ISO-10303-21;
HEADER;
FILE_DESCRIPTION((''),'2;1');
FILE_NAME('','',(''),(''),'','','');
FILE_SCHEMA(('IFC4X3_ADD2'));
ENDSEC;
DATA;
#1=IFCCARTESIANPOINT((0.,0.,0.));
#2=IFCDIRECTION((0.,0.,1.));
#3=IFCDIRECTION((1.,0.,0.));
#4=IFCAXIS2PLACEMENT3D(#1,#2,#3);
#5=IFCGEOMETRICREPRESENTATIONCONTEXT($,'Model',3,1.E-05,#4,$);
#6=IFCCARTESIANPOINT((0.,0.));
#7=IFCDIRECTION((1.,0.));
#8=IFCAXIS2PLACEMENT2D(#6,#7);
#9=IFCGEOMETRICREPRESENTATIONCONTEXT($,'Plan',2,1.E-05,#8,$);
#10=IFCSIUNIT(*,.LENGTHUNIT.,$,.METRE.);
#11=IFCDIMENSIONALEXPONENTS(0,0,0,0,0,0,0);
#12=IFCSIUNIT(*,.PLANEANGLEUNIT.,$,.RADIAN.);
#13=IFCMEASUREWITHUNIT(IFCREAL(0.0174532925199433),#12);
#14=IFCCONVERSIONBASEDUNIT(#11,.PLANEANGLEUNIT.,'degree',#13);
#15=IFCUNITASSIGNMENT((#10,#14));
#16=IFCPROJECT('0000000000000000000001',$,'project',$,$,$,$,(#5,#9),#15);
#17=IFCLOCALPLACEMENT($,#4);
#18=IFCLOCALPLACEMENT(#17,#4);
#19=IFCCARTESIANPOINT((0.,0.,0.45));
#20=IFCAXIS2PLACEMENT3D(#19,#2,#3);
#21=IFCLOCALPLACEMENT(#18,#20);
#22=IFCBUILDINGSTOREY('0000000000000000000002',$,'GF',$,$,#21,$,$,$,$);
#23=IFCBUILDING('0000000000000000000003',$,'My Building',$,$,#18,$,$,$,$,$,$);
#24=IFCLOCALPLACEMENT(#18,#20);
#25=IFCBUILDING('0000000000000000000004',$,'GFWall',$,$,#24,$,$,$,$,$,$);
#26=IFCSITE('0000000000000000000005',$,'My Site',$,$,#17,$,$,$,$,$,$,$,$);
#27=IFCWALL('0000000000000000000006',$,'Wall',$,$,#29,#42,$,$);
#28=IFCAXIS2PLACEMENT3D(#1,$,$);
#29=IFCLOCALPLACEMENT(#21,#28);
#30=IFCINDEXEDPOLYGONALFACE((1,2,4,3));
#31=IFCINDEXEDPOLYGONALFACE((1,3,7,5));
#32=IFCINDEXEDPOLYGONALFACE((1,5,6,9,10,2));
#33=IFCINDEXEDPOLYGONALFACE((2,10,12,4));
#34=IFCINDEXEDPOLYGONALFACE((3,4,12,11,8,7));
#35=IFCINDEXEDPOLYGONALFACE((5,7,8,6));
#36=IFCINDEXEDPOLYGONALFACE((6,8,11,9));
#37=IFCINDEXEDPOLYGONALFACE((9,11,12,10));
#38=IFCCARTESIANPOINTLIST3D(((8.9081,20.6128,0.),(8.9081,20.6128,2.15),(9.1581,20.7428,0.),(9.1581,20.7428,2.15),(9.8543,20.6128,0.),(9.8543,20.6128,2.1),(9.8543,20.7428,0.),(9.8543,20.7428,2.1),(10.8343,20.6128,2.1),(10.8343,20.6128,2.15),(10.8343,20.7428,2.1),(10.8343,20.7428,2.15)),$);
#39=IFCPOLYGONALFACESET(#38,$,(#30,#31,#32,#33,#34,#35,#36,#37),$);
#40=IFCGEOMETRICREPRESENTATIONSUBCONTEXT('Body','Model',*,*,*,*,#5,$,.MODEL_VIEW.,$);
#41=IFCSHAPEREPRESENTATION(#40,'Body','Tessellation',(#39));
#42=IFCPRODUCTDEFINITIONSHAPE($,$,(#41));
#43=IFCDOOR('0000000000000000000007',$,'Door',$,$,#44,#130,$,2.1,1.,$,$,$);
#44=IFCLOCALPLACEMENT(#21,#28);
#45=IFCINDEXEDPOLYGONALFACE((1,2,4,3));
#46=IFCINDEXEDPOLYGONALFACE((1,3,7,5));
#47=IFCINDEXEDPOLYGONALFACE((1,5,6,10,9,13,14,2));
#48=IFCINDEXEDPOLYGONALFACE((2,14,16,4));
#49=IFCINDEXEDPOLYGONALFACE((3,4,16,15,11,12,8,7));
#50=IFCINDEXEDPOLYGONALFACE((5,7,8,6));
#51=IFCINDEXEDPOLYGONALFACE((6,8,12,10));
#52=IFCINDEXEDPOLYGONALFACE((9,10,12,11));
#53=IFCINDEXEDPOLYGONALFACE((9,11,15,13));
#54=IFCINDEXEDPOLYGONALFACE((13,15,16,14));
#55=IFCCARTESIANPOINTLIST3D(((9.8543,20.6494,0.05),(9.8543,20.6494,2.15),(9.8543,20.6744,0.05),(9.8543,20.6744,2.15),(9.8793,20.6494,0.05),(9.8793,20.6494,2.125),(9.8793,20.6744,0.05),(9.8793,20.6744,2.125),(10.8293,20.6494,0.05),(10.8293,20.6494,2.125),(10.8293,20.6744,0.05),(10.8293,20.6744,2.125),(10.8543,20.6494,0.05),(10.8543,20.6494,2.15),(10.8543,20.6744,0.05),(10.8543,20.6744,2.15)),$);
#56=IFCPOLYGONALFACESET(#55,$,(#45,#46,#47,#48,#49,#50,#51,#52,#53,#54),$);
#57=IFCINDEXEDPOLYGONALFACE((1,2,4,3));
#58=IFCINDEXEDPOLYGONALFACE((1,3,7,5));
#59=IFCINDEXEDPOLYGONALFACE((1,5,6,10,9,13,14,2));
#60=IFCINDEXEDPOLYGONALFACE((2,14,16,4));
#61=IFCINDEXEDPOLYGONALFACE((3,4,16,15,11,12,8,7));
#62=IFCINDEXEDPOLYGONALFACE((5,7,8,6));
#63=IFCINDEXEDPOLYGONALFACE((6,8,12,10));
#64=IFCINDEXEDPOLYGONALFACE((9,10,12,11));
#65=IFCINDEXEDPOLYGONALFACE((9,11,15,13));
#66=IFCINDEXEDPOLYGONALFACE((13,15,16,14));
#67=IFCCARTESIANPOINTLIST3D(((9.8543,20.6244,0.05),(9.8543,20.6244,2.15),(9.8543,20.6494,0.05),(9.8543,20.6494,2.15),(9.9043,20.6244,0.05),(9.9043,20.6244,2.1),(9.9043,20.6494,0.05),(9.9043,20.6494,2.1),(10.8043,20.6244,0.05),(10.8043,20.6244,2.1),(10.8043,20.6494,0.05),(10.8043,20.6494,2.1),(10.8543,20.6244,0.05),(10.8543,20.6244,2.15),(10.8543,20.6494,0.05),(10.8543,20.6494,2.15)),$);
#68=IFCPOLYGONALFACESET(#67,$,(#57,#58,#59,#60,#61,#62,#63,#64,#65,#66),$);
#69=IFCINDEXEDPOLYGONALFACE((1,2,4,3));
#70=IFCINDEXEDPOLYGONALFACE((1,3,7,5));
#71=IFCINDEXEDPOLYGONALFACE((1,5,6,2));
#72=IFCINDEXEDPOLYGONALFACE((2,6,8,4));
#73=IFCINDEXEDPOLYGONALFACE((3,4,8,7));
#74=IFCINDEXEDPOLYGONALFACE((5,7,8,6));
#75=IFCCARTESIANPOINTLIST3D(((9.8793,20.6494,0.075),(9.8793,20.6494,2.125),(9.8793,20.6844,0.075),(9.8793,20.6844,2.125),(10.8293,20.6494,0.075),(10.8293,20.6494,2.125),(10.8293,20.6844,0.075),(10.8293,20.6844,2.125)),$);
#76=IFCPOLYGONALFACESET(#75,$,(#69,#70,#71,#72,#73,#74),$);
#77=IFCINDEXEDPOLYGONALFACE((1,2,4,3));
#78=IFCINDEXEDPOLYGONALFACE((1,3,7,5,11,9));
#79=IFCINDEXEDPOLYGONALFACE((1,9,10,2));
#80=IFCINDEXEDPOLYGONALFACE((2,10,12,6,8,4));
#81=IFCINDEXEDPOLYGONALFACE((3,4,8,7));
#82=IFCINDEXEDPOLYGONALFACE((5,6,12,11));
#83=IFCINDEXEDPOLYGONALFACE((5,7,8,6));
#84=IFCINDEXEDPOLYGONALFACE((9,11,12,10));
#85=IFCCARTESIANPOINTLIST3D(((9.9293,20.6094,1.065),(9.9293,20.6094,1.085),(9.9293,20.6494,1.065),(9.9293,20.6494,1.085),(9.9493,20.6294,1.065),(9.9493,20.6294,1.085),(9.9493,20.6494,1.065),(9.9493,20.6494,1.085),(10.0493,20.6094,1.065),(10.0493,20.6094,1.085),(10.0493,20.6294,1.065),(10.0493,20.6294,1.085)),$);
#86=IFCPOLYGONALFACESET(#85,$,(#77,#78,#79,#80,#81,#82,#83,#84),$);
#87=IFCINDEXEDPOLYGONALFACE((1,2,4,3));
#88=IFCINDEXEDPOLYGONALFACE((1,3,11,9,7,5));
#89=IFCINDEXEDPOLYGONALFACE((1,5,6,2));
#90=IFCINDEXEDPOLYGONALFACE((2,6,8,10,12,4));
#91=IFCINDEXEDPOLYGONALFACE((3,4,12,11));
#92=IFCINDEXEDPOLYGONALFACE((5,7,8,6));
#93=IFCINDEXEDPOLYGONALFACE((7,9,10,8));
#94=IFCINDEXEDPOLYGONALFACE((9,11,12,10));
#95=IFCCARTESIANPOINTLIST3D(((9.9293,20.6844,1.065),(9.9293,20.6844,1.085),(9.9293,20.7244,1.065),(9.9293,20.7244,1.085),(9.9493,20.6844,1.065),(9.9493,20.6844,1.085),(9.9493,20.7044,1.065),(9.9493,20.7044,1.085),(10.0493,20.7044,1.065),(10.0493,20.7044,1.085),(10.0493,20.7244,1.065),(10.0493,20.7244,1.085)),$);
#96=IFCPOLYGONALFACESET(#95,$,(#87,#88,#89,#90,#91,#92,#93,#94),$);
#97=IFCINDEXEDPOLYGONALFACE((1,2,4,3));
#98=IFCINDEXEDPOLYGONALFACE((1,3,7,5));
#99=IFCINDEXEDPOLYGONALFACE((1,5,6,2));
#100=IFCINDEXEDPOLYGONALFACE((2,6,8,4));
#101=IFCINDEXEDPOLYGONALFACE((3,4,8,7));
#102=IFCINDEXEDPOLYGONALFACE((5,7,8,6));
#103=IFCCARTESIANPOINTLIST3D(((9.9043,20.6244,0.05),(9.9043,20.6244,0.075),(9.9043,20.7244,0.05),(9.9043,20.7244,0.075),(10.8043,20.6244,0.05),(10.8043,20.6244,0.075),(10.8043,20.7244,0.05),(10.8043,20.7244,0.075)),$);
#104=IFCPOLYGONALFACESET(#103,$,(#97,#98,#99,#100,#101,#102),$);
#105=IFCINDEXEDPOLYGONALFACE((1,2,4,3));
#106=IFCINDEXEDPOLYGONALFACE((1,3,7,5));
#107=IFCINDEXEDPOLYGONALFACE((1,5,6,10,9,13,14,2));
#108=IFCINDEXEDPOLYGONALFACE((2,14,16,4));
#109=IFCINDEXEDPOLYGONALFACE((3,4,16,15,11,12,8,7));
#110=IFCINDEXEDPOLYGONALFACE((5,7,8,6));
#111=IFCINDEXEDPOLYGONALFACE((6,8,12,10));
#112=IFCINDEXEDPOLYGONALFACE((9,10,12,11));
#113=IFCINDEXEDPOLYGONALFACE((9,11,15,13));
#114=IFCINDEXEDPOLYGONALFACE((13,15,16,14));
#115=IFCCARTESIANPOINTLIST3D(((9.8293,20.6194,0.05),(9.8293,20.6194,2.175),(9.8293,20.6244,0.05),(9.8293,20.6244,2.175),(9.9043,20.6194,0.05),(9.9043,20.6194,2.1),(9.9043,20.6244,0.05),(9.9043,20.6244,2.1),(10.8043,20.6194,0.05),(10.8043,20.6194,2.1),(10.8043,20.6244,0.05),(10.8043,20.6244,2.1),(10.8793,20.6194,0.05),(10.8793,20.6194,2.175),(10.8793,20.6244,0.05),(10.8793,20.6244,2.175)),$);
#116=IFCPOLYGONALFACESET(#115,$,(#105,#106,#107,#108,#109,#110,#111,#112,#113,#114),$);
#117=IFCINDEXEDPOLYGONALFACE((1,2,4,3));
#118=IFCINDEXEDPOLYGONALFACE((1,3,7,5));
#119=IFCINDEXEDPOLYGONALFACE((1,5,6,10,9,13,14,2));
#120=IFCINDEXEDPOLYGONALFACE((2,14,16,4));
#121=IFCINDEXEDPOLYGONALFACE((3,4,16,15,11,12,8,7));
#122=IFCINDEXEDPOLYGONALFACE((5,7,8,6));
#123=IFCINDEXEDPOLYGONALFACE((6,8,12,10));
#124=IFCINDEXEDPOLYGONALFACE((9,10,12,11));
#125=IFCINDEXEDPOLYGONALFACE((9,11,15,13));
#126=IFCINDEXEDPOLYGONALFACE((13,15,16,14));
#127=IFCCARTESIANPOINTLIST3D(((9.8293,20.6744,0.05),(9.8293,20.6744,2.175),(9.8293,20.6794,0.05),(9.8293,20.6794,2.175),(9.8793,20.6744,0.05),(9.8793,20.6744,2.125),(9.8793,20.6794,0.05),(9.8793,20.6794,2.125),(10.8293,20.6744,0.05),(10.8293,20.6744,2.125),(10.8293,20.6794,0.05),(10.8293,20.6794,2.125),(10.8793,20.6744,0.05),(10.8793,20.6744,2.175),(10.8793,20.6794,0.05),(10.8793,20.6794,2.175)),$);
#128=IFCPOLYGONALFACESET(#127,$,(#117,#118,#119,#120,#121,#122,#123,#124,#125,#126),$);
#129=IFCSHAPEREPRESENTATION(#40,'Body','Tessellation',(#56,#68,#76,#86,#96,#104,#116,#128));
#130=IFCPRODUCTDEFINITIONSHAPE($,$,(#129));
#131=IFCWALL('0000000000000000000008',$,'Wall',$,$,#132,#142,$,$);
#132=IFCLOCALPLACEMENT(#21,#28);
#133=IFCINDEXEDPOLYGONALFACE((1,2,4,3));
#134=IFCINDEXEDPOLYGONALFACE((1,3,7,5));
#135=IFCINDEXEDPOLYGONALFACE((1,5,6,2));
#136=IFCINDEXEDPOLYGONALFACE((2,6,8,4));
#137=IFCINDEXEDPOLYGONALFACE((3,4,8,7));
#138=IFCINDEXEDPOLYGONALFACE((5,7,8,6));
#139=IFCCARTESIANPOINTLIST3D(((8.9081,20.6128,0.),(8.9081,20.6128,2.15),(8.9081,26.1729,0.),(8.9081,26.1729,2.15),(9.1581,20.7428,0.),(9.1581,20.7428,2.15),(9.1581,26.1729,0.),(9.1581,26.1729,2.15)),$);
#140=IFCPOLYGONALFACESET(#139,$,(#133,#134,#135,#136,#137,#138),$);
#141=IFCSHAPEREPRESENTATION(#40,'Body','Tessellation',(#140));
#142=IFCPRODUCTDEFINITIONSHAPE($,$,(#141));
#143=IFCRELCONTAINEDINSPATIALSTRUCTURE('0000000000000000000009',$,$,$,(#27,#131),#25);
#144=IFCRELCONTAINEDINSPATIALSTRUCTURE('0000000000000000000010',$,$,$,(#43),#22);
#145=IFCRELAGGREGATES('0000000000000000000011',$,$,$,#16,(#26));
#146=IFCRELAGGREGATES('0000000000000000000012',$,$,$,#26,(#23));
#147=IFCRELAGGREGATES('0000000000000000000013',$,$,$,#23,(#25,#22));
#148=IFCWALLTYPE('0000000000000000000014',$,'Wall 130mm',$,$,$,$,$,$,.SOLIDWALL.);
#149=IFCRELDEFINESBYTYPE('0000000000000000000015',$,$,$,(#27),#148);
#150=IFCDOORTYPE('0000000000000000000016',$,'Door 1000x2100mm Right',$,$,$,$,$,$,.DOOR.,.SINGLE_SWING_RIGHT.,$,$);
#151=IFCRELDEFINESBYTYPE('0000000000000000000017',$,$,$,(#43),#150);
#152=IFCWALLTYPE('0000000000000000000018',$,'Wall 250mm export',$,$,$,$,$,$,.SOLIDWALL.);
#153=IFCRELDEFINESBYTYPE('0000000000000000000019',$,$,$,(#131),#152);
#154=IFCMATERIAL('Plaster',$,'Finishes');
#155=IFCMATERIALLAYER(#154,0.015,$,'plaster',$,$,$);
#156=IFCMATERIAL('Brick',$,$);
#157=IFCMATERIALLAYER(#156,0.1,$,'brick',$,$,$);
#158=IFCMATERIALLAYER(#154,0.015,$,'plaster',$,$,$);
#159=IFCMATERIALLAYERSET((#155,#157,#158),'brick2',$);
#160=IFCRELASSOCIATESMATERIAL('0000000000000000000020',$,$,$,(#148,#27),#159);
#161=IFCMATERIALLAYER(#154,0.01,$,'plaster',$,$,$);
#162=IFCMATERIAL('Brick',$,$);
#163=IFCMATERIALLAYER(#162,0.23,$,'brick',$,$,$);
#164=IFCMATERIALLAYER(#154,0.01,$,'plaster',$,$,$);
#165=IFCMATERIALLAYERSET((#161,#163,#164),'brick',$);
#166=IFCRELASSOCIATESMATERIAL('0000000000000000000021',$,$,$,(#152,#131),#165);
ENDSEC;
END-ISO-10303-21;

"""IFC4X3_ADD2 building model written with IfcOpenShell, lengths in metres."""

from ifc_helpers import new_model, entity, si_unit, converted_unit, frame, origin_with_axes, origin_2d_with_axis, place, context, subcontext, project, spatial, line, indexed_curve, outline, extrude, shape, source, transform, mapped, material, layer, layer_set, layer_usage, type_object, type_shapes, element, fill, save


model = new_model("IFC4X3_ADD2")

# Units and contexts
model_context = context("Model", 3, precision=1e-05, world=origin_with_axes())
plan_context = context("Plan", 2, precision=1e-05, world=origin_2d_with_axis())
body_context_1 = subcontext(model_context, "Body", "Model", "MODEL_VIEW")
body_context_2 = subcontext(plan_context, "Body", "Plan", "PLAN_VIEW")
ifc_project = project(units=[si_unit("LENGTHUNIT", "METRE"), converted_unit("PLANEANGLEUNIT", "degree", entity("IfcReal", 0.0174532925199433), si_unit("PLANEANGLEUNIT", "RADIAN"), dimensions=[0, 0, 0, 0, 0, 0, 0])], contexts=[model_context, plan_context])

# Site, buildings
site_placement = place(None, origin_with_axes())
site = spatial("IfcSite", under=ifc_project, at=site_placement, Name="My Site")
building_1_placement = place(site_placement, origin_with_axes())
building_1 = spatial("IfcBuilding", under=site, at=building_1_placement, Name="My Building")
building_2_placement = place(building_1_placement, frame((0.0, 0.0, 0.45), z_axis=(0.0, 0.0, 1.0), x_axis=(1.0, 0.0, 0.0)))
building_2 = spatial("IfcBuilding", under=building_1, at=building_2_placement, Name="GFWall")

# Shared definitions
ifc_material_1 = material(Name="Plaster", Category="Finishes")
ifc_layer_1 = layer(ifc_material_1, 0.015, Name="plaster")
ifc_material_2 = material(Name="Brick")
ifc_layer_2 = layer(ifc_material_2, 0.1, Name="brick")
ifc_layer_3 = layer(ifc_material_1, 0.015, Name="plaster")
ifc_layer_set_1 = layer_set([ifc_layer_1, ifc_layer_2, ifc_layer_3], Name="brick2")
wall_type_1 = type_object("IfcWallType", Name="Wall 130mm", PredefinedType="SOLIDWALL", material=ifc_layer_set_1)
shared_shape_1 = source(origin_with_axes(), body_context_1, "Body", "SweptSolid", [
    extrude(outline(indexed_curve([(0.0, 0.0), (1.0, 0.0), (1.0, 2.1), (0.0, 2.1)], segments=[line(1, 2, 3, 4, 1)])), frame((0.0, -0.6, 0.0), z_axis=(0.0, -1.0, 0.0), x_axis=(1.0, 0.0, 0.0)), (0.0, 0.0, -1.0), 1.2),
])

# Shared definitions
storey_placement = place(building_1_placement, frame((0.0, 0.0, 0.45), z_axis=(0.0, 0.0, 1.0), x_axis=(1.0, 0.0, 0.0)))
storey = spatial("IfcBuildingStorey", under=building_1, at=storey_placement, Name="GF")

# Shared definitions
door_type_1 = type_object("IfcDoorType", Name="Door 1000x2100mm Right", OperationType="SINGLE_SWING_RIGHT", PredefinedType="DOOR")
shared_shape_2 = source(origin_with_axes(), body_context_1, "Body", "SweptSolid", [
    extrude(outline(indexed_curve([(0.0, 0.0), (0.0, 2.1), (1.0, 2.1), (1.0, 0.0), (0.975, 0.0), (0.975, 2.075), (0.025, 2.075), (0.025, 0.0)], segments=[line(1, 2, 3, 4, 5, 6, 7, 8, 1)])), frame((0.0, 0.025, 0.0), z_axis=(0.0, -1.0, 0.0), x_axis=(1.0, 0.0, 0.0)), (0.0, 0.0, -1.0), 0.025),
    extrude(outline(indexed_curve([(0.0, 0.0), (0.0, 2.1), (1.0, 2.1), (1.0, 0.0), (0.95, 0.0), (0.95, 2.05), (0.05, 2.05), (0.05, 0.0)], segments=[line(1, 2, 3, 4, 5, 6, 7, 8, 1)])), frame((0.0, 0.0, 0.0), z_axis=(0.0, -1.0, 0.0), x_axis=(1.0, 0.0, 0.0)), (0.0, 0.0, -1.0), 0.025),
    extrude(outline(indexed_curve([(0.0, 0.0), (0.95, 0.0), (0.95, 0.035), (0.0, 0.035)], segments=[line(1, 2, 3, 4, 1)])), frame((0.025, 0.025, 0.025), z_axis=(0.0, 0.0, 1.0), x_axis=(1.0, 0.0, 0.0)), (0.0, 0.0, 1.0), 2.05),
    extrude(outline(indexed_curve([(0.0, 0.0), (0.0, -0.04), (0.12, -0.04), (0.12, -0.02), (0.02, -0.02), (0.02, 0.0)], segments=[line(1, 2, 3, 4, 5, 6, 1)])), frame((0.075, 0.025, 1.015), z_axis=(0.0, 0.0, 1.0), x_axis=(1.0, 0.0, 0.0)), (0.0, 0.0, 1.0), 0.02),
    extrude(outline(indexed_curve([(0.0, 0.0), (0.0, 0.04), (0.12, 0.04), (0.12, 0.02), (0.02, 0.02), (0.02, 0.0)], segments=[line(1, 2, 3, 4, 5, 6, 1)])), frame((0.075, 0.06, 1.015), z_axis=(0.0, 0.0, 1.0), x_axis=(1.0, 0.0, 0.0)), (0.0, 0.0, 1.0), 0.02),
    extrude(outline(indexed_curve([(0.0, 0.0), (0.9, 0.0), (0.9, 0.1), (0.0, 0.1)], segments=[line(1, 2, 3, 4, 1)])), frame((0.05, 0.0, 0.0), z_axis=(0.0, 0.0, 1.0), x_axis=(1.0, 0.0, 0.0)), (0.0, 0.0, 1.0), 0.025),
    extrude(outline(indexed_curve([(0.0, 0.0), (0.0, 2.125), (1.05, 2.125), (1.05, 0.0), (0.975, 0.0), (0.975, 2.05), (0.075, 2.05), (0.075, 0.0)], segments=[line(1, 2, 3, 4, 5, 6, 7, 8, 1)])), frame((-0.025, -0.005, 0.0), z_axis=(0.0, -1.0, 0.0), x_axis=(1.0, 0.0, 0.0)), (0.0, 0.0, -1.0), 0.005),
    extrude(outline(indexed_curve([(0.0, 0.0), (0.0, 2.125), (1.05, 2.125), (1.05, 0.0), (1.0, 0.0), (1.0, 2.075), (0.05, 2.075), (0.05, 0.0)], segments=[line(1, 2, 3, 4, 5, 6, 7, 8, 1)])), frame((-0.025, 0.05, 0.0), z_axis=(0.0, -1.0, 0.0), x_axis=(1.0, 0.0, 0.0)), (0.0, 0.0, -1.0), 0.005),
])
shared_shape_3 = source(origin_with_axes(), body_context_2, "Body", "Curve2D", [
    entity("IfcIndexedPolyCurve", entity("IfcCartesianPointList2D", [[0.0, 0.0], [0.0, 0.05], [0.025, 0.05], [0.025, 0.025], [0.05, 0.025], [0.05, 0.0]]), [entity("IfcLineIndex", [1, 2, 3, 4, 5, 6, 1])]),
    entity("IfcIndexedPolyCurve", entity("IfcCartesianPointList2D", [[1.0, 0.0], [1.0, 0.05], [0.975, 0.05], [0.975, 0.025], [0.95, 0.025], [0.95, 0.0]]), [entity("IfcLineIndex", [1, 2, 3, 4, 5, 6, 1])]),
    entity("IfcTrimmedCurve", entity("IfcEllipse", entity("IfcAxis2Placement2D", entity("IfcCartesianPoint", [0.94, 0.05]), entity("IfcDirection", [1.0, 0.0])), 0.915, 0.95), [entity("IfcCartesianPoint", [0.94, 1.0])], [entity("IfcCartesianPoint", [0.025, 0.05])], True, "CARTESIAN"),
    entity("IfcIndexedPolyCurve", entity("IfcCartesianPointList2D", [[0.975, 0.05], [0.94, 0.05], [0.94, 1.0], [0.975, 1.0]]), [entity("IfcLineIndex", [1, 2, 3, 4, 1])]),
])
type_shapes(door_type_1, [shared_shape_2, shared_shape_3])

# Wall, opening, door
ifc_layer_usage_1 = layer_usage(ifc_layer_set_1, "AXIS2", "POSITIVE", 0.0)
wall_1_placement = place(building_2_placement, frame((9.1581, 20.6128, 0.0), z_axis=(0.0, 0.0, 1.0), x_axis=(1.0, 0.0, 0.0)))
wall_1 = element("IfcWall", 1, at=wall_1_placement, inside=building_2, type_object=wall_type_1, material=ifc_layer_usage_1, Name="Wall", context=body_context_1, shape_type="SweptSolid", body=[
    extrude(outline(indexed_curve([(-0.25, 0.0), (0.0, 0.13), (1.6762, 0.13), (1.6762, 0.0)], segments=[line(1, 2, 3, 4, 1)])), origin_with_axes(), (0.0, 0.0, 1.0), 2.15),
])
opening_1_placement = place(wall_1_placement, frame((0.6962, 0.0, 0.0), z_axis=(0.0, 0.0, 1.0), x_axis=(1.0, 0.0, 0.0)))
opening_1 = element("IfcOpeningElement", 2, at=opening_1_placement, cuts=wall_1, PredefinedType="OPENING", context=body_context_1, shape_type="MappedRepresentation", body=[
    mapped(shared_shape_1, transform((0.0, 0.0, 0.0), x_axis=(1.0, 0.0, 0.0), y_axis=(0.0, 1.0, 0.0), z_axis=(0.0, 0.0, 1.0), scale=1.0)),
])
door_1_placement = place(opening_1_placement, frame((0.0, 0.0116, 0.05), z_axis=(0.0, 0.0, 1.0), x_axis=(1.0, 0.0, 0.0)))
door_1 = element("IfcDoor", 3, at=door_1_placement, inside=storey, type_object=door_type_1, Name="Door", OverallHeight=2.1, OverallWidth=1.0, shapes=[
    shape(body_context_1, "Body", "MappedRepresentation", [mapped(shared_shape_2, transform((0.0, 0.0, 0.0), x_axis=(1.0, 0.0, 0.0), y_axis=(0.0, 1.0, 0.0), z_axis=(0.0, 0.0, 1.0), scale=1.0))]),
    shape(body_context_2, "Body", "MappedRepresentation", [mapped(shared_shape_3, transform((0.0, 0.0, 0.0), x_axis=(1.0, 0.0, 0.0), y_axis=(0.0, 1.0, 0.0), z_axis=(0.0, 0.0, 1.0), scale=1.0))]),
])
fill(opening_1, door_1)

# Shared definitions
ifc_layer_4 = layer(ifc_material_1, 0.01, Name="plaster")
ifc_material_3 = material(Name="Brick")
ifc_layer_5 = layer(ifc_material_3, 0.23, Name="brick")
ifc_layer_6 = layer(ifc_material_1, 0.01, Name="plaster")
ifc_layer_set_2 = layer_set([ifc_layer_4, ifc_layer_5, ifc_layer_6], Name="brick")
wall_type_2 = type_object("IfcWallType", Name="Wall 250mm export", PredefinedType="SOLIDWALL", material=ifc_layer_set_2)

# Wall
ifc_layer_usage_2 = layer_usage(ifc_layer_set_2, "AXIS2", "POSITIVE", 0.0)
wall_2_placement = place(building_2_placement, frame((9.1581, 20.6128, 0.0), z_axis=(0.0, 0.0, 1.0), x_axis=(0.0, 1.0, 0.0)))
element("IfcWall", 4, at=wall_2_placement, inside=building_2, type_object=wall_type_2, material=ifc_layer_usage_2, Name="Wall", context=body_context_1, shape_type="SweptSolid", body=[
    extrude(outline(indexed_curve([(0.13, 0.0), (0.0, 0.25), (5.5601, 0.25), (5.5601, 0.0)], segments=[line(1, 2, 3, 4, 1)])), origin_with_axes(), (0.0, 0.0, 1.0), 2.15),
])

save(model, "model.ifc")
